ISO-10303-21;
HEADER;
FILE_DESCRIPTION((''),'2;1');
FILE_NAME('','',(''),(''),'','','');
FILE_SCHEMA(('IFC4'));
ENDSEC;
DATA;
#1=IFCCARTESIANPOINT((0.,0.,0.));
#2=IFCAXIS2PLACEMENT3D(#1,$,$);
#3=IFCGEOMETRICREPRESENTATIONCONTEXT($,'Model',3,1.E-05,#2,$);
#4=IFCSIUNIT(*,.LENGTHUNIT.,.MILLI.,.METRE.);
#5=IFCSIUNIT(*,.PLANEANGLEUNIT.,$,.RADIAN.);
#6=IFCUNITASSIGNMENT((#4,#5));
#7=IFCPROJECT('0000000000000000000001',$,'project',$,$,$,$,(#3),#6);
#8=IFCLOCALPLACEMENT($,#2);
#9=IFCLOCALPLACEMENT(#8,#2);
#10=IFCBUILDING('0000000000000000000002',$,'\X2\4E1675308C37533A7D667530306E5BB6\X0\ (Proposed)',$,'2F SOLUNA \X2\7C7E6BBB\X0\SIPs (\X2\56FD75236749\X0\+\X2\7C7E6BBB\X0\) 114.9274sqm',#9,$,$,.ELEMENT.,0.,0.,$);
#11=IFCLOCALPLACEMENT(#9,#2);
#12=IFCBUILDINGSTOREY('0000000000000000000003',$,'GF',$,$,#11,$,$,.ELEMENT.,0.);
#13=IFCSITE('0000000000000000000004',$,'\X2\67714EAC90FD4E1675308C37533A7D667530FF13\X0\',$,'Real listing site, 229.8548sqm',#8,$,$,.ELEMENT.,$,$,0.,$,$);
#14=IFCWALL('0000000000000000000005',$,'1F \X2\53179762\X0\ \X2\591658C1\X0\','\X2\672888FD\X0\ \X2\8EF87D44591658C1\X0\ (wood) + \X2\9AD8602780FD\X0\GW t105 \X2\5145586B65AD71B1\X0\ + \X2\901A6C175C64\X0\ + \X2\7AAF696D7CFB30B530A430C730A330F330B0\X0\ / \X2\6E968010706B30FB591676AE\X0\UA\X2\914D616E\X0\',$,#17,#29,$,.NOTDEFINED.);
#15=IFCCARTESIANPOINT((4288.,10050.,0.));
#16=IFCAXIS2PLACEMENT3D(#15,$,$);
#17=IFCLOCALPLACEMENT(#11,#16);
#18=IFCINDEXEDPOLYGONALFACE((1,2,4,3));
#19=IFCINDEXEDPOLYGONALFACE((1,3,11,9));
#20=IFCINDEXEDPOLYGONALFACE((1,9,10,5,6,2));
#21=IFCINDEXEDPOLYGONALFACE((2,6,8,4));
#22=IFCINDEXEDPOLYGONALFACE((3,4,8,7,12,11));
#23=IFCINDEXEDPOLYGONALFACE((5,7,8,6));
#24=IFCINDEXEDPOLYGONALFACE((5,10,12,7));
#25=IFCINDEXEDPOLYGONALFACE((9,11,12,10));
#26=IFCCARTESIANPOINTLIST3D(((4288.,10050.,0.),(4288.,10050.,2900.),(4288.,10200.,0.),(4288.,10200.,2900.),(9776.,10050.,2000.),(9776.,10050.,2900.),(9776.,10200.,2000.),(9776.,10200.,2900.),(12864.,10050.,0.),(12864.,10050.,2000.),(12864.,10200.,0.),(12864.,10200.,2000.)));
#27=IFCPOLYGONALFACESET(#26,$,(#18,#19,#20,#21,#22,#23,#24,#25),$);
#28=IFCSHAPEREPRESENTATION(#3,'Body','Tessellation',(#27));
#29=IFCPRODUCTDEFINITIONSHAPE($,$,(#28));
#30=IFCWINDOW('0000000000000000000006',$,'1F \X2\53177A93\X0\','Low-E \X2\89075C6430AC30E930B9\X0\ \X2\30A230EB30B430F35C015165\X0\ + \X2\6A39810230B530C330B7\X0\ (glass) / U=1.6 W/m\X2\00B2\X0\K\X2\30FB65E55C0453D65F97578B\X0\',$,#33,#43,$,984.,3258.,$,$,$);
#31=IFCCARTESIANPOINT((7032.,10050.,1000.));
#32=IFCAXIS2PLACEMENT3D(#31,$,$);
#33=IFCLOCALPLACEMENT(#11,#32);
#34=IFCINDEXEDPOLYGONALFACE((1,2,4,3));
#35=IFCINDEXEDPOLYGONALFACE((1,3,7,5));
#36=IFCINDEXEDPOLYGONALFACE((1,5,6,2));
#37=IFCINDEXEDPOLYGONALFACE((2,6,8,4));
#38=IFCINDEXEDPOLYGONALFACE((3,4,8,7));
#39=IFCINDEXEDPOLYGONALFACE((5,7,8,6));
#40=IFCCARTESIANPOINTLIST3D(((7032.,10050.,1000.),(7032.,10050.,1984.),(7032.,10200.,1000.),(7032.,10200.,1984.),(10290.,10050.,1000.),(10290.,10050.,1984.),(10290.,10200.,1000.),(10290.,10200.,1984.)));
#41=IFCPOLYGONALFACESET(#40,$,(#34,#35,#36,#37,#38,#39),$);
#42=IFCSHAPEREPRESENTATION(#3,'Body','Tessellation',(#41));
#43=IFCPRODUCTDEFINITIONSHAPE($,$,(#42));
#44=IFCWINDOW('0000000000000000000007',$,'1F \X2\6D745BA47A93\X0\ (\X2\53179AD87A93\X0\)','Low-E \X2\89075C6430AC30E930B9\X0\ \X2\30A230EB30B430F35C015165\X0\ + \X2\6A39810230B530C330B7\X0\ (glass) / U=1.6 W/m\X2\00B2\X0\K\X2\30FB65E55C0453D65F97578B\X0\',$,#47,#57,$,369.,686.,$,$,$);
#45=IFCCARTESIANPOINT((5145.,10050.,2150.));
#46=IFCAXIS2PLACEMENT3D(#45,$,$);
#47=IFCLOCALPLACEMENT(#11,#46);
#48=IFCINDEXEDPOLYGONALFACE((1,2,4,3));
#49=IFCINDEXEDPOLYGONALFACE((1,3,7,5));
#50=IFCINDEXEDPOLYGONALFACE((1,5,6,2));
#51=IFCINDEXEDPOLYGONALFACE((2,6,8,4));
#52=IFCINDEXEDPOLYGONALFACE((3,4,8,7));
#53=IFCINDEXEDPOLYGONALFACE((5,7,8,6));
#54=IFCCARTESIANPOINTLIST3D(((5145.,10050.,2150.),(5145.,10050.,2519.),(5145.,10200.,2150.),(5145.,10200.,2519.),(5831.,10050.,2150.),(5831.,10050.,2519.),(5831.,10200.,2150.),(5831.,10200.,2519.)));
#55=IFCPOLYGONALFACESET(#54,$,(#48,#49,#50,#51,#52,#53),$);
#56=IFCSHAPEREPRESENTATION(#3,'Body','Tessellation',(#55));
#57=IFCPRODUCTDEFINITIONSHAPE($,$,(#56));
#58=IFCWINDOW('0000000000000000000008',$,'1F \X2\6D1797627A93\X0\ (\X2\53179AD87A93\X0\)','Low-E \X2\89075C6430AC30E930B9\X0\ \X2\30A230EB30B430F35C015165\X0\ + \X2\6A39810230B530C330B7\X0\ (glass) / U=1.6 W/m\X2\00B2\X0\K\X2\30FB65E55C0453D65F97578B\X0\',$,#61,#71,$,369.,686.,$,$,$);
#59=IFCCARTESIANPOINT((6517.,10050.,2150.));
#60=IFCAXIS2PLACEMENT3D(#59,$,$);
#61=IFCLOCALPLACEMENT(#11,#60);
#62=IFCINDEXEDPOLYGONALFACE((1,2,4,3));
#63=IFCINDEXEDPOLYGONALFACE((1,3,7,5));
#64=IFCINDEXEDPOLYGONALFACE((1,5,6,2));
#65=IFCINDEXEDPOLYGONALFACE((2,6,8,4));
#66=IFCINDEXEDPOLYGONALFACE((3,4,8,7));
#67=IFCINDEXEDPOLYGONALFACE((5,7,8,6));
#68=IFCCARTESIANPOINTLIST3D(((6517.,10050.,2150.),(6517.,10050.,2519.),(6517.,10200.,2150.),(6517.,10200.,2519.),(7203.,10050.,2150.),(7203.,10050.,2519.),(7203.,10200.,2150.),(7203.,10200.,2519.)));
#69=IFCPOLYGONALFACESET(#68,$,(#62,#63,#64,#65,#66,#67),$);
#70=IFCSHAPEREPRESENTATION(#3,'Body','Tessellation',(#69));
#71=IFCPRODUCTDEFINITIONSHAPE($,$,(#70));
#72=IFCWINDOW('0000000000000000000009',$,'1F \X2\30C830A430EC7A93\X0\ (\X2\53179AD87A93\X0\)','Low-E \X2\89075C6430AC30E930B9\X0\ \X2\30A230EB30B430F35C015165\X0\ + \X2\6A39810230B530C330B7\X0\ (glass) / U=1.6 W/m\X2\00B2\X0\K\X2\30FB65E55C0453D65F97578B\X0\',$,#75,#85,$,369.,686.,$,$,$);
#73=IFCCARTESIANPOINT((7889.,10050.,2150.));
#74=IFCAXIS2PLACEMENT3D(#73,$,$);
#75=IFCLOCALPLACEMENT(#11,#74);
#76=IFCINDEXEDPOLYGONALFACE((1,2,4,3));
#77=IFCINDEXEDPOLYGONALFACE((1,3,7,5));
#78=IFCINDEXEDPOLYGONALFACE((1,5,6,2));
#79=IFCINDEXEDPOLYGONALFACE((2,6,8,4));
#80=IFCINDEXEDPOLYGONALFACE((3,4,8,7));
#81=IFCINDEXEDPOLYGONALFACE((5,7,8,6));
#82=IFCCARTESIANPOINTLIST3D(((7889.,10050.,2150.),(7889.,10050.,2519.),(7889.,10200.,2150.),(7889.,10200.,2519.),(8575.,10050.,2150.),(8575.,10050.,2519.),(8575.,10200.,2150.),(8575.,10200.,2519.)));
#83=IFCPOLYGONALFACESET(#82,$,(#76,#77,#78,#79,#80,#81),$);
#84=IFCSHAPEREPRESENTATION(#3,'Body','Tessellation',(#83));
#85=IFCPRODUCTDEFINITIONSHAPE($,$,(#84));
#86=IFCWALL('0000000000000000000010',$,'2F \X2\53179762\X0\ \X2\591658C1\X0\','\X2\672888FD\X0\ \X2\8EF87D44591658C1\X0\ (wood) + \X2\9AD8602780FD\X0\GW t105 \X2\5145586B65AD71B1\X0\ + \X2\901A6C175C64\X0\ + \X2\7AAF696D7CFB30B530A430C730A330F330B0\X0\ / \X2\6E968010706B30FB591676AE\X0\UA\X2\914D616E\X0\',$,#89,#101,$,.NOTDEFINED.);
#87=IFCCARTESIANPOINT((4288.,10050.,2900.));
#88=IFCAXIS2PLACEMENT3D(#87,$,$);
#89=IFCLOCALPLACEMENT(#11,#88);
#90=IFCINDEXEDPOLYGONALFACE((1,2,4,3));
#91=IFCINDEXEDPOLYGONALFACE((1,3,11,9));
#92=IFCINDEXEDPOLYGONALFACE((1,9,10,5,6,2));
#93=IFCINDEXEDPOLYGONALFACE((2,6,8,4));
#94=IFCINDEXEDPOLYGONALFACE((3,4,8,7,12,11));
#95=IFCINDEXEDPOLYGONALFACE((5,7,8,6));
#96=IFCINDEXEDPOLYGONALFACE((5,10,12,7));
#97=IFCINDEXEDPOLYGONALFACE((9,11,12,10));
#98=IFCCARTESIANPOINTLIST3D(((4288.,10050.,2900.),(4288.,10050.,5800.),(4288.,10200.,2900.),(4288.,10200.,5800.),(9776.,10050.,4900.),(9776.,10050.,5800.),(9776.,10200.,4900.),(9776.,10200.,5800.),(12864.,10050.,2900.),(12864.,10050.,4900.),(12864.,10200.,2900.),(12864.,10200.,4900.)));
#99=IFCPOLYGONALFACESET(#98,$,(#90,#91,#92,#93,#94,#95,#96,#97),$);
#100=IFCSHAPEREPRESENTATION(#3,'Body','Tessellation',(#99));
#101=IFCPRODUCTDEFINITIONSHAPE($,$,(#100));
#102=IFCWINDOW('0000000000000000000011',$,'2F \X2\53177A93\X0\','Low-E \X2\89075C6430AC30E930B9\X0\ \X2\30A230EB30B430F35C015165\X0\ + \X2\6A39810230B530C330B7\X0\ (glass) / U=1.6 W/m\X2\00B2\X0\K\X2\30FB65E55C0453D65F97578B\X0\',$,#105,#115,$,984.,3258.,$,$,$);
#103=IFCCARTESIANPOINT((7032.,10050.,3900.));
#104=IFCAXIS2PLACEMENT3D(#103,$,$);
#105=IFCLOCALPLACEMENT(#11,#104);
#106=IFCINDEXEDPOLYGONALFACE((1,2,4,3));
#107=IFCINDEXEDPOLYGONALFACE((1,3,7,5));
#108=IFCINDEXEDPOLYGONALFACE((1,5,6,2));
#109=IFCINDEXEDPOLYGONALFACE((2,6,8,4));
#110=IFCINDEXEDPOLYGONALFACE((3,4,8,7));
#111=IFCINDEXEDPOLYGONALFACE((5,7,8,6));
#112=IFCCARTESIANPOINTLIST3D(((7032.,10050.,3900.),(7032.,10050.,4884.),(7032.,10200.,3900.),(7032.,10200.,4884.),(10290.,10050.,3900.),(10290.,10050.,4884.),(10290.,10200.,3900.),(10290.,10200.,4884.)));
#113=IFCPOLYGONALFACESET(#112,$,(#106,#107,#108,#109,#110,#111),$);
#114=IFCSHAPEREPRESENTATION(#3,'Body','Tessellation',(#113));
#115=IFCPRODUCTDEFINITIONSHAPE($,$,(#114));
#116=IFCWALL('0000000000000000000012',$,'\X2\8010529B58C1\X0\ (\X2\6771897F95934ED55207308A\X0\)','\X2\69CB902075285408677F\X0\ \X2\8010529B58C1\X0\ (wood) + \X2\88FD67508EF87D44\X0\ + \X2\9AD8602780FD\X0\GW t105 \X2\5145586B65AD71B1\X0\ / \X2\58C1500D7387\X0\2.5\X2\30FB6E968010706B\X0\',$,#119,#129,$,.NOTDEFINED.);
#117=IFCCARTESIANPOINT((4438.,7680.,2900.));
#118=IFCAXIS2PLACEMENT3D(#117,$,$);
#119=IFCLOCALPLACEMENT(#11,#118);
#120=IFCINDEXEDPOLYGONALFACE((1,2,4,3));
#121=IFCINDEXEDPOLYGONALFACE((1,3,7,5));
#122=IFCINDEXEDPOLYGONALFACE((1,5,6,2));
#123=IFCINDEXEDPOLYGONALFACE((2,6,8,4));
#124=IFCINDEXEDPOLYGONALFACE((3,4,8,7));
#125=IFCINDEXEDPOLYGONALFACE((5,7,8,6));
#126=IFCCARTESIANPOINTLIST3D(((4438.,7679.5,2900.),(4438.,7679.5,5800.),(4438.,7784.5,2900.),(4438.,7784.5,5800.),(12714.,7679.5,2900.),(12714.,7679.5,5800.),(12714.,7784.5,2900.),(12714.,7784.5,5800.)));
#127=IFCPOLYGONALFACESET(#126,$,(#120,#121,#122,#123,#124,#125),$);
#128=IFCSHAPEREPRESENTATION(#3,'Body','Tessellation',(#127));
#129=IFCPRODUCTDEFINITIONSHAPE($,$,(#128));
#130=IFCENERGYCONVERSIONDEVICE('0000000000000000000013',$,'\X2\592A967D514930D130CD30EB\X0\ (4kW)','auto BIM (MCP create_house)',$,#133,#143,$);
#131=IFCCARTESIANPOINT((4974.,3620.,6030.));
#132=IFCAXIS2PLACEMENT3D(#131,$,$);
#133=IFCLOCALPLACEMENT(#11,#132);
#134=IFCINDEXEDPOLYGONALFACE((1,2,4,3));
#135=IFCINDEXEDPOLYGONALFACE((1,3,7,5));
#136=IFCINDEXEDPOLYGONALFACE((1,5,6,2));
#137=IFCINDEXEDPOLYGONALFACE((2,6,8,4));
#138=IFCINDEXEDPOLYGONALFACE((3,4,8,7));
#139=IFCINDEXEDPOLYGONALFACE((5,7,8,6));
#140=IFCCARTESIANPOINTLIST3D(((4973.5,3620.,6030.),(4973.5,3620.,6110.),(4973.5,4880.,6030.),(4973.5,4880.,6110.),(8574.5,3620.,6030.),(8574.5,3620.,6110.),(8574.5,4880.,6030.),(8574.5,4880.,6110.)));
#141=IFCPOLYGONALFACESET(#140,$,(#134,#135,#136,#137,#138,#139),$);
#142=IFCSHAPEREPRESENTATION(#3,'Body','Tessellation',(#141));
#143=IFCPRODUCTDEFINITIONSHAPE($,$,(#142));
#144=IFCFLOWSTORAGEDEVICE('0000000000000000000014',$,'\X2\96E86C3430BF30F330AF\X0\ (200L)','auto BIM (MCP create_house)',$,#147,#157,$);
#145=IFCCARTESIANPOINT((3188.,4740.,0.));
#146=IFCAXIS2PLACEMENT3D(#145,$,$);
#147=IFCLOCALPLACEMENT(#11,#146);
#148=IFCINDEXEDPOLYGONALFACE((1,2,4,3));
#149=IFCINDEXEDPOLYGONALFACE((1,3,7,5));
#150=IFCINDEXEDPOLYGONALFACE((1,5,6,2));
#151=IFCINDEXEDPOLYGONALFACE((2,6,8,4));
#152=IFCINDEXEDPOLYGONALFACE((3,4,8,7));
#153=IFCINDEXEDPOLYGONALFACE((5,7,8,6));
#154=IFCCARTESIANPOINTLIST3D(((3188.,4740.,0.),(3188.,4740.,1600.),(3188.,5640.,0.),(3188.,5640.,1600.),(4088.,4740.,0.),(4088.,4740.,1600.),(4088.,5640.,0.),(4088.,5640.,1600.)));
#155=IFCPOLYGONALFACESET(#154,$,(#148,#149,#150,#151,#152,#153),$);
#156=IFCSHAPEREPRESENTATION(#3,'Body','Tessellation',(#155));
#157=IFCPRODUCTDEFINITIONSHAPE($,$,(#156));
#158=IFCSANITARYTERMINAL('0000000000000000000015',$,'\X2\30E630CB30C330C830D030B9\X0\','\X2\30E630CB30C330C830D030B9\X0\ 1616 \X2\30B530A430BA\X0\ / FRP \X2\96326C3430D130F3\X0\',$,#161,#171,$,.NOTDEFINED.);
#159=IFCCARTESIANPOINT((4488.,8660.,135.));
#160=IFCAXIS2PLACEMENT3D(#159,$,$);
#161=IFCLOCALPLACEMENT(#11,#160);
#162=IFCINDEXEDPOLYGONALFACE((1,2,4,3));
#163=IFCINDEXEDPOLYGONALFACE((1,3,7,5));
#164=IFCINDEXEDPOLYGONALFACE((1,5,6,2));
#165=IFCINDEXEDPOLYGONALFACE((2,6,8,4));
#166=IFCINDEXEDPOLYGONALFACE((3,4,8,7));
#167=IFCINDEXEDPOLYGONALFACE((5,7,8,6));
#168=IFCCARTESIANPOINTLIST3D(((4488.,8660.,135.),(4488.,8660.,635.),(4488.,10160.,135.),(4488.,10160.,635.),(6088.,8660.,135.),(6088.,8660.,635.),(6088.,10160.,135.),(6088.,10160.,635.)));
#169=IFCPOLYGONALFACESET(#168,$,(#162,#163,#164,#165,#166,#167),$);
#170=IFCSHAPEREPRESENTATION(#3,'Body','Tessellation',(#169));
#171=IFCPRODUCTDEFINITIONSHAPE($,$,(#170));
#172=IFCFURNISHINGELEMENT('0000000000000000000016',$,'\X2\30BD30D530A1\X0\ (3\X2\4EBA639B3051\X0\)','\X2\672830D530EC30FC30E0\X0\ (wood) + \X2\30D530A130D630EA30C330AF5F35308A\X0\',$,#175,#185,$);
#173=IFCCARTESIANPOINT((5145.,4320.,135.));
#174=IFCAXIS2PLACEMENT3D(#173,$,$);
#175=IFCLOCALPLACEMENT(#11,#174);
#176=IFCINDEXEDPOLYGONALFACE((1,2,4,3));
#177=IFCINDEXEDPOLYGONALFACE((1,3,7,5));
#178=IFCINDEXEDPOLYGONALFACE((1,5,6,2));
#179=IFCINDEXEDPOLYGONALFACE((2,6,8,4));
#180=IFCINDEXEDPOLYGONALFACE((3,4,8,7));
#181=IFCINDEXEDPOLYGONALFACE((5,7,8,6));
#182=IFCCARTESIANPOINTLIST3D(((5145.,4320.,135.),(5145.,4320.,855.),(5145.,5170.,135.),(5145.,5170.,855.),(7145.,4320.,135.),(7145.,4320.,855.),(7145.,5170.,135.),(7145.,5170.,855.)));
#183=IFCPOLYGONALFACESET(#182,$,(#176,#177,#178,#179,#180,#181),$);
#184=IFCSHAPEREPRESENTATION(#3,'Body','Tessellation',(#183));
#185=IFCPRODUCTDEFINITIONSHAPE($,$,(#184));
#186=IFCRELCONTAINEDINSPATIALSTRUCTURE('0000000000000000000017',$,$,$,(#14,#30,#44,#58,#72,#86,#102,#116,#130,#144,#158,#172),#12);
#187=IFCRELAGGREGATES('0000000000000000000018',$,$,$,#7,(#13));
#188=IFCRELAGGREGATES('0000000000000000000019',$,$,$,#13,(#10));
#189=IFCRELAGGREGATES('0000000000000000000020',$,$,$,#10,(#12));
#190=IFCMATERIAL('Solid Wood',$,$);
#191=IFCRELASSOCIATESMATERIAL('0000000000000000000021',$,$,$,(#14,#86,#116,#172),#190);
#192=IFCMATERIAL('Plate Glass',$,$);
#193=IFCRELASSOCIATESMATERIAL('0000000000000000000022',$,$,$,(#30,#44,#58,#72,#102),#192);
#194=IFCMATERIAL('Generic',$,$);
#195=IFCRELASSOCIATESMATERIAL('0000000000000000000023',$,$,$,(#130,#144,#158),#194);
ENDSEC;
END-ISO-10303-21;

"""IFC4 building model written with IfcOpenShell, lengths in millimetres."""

from ifc_helpers import new_model, si_unit, frame, frame_2d, origin, place, context, project, spatial, rectangle, extrude, material, element, fill, save


model = new_model("IFC4")

# Units and contexts
model_context = context("Model", 3, precision=1e-05, world=origin())
ifc_project = project(units=[si_unit("LENGTHUNIT", "METRE", prefix="MILLI"), si_unit("PLANEANGLEUNIT", "RADIAN")], contexts=[model_context])

# Site, building, storey
site_placement = place(None, origin())
site = spatial("IfcSite", under=ifc_project, at=site_placement, Name="東京都世田谷区給田３", ObjectType="Real listing site, 229.8548sqm", CompositionType="ELEMENT", RefElevation=0.0)
building_placement = place(site_placement, origin())
building = spatial("IfcBuilding", under=site, at=building_placement, Name="世田谷区給田の家 (Proposed)", ObjectType="2F SOLUNA 籾殻SIPs (国産杉+籾殻) 114.9274sqm", CompositionType="ELEMENT", ElevationOfRefHeight=0.0, ElevationOfTerrain=0.0)
storey_placement = place(building_placement, origin())
storey = spatial("IfcBuildingStorey", under=building, at=storey_placement, Name="GF", CompositionType="ELEMENT", Elevation=0.0)

# Wall, openings, windows
ifc_material_1 = material(Name="Solid Wood")
wall_1_placement = place(storey_placement, frame((4288.0, 10050.0, 0.0)))
wall_1 = element("IfcWall", 1, at=wall_1_placement, inside=storey, material=ifc_material_1, Name="1F 北面 外壁", Description="木製 軸組外壁 (wood) + 高性能GW t105 充填断熱 + 通気層 + 窯業系サイディング / 準耐火・外皮UA配慮", PredefinedType="NOTDEFINED", context=model_context, shape_type="SweptSolid", body=[
    extrude(rectangle(XDim=8576.0, YDim=150.0, at=frame_2d((4288.0, 75.0))), frame((4288.0, 10050.0, 0.0)), (0.0, 0.0, 1.0), 2900.0),
])
opening_1_placement = place(storey_placement, frame((7032.0, 10050.0, 1000.0)))
opening_1 = element("IfcOpeningElement", 2, at=opening_1_placement, cuts=wall_1, PredefinedType="NOTDEFINED", context=model_context, shape_type="SweptSolid", body=[
    extrude(rectangle(XDim=3258.0, YDim=150.0, at=frame_2d((1629.0, 75.0))), frame((7032.0, 10050.0, 1000.0)), (0.0, 0.0, 1.0), 984.0),
])
opening_2_placement = place(storey_placement, frame((5145.0, 10050.0, 2150.0)))
opening_2 = element("IfcOpeningElement", 3, at=opening_2_placement, cuts=wall_1, PredefinedType="NOTDEFINED", context=model_context, shape_type="SweptSolid", body=[
    extrude(rectangle(XDim=686.0, YDim=150.0, at=frame_2d((343.0, 75.0))), frame((5145.0, 10050.0, 2150.0)), (0.0, 0.0, 1.0), 369.0),
])
opening_3_placement = place(storey_placement, frame((6517.0, 10050.0, 2150.0)))
opening_3 = element("IfcOpeningElement", 4, at=opening_3_placement, cuts=wall_1, PredefinedType="NOTDEFINED", context=model_context, shape_type="SweptSolid", body=[
    extrude(rectangle(XDim=686.0, YDim=150.0, at=frame_2d((343.0, 75.0))), frame((6517.0, 10050.0, 2150.0)), (0.0, 0.0, 1.0), 369.0),
])
opening_4_placement = place(storey_placement, frame((7889.0, 10050.0, 2150.0)))
opening_4 = element("IfcOpeningElement", 5, at=opening_4_placement, cuts=wall_1, PredefinedType="NOTDEFINED", context=model_context, shape_type="SweptSolid", body=[
    extrude(rectangle(XDim=686.0, YDim=150.0, at=frame_2d((343.0, 75.0))), frame((7889.0, 10050.0, 2150.0)), (0.0, 0.0, 1.0), 369.0),
])
ifc_material_2 = material(Name="Plate Glass")
window_1_placement = place(storey_placement, frame((7032.0, 10050.0, 1000.0)))
window_1 = element("IfcWindow", 6, at=window_1_placement, inside=storey, material=ifc_material_2, Name="1F 北窓", Description="Low-E 複層ガラス アルゴン封入 + 樹脂サッシ (glass) / U=1.6 W/m²K・日射取得型", OverallHeight=984.0, OverallWidth=3258.0, context=model_context, shape_type="SweptSolid", body=[
    extrude(rectangle(XDim=3258.0, YDim=150.0, at=frame_2d((1629.0, 75.0))), frame((7032.0, 10050.0, 1000.0)), (0.0, 0.0, 1.0), 984.0),
])
fill(opening_1, window_1)
window_2_placement = place(storey_placement, frame((5145.0, 10050.0, 2150.0)))
window_2 = element("IfcWindow", 7, at=window_2_placement, inside=storey, material=ifc_material_2, Name="1F 浴室窓 (北高窓)", Description="Low-E 複層ガラス アルゴン封入 + 樹脂サッシ (glass) / U=1.6 W/m²K・日射取得型", OverallHeight=369.0, OverallWidth=686.0, context=model_context, shape_type="SweptSolid", body=[
    extrude(rectangle(XDim=686.0, YDim=150.0, at=frame_2d((343.0, 75.0))), frame((5145.0, 10050.0, 2150.0)), (0.0, 0.0, 1.0), 369.0),
])
fill(opening_2, window_2)
window_3_placement = place(storey_placement, frame((6517.0, 10050.0, 2150.0)))
window_3 = element("IfcWindow", 8, at=window_3_placement, inside=storey, material=ifc_material_2, Name="1F 洗面窓 (北高窓)", Description="Low-E 複層ガラス アルゴン封入 + 樹脂サッシ (glass) / U=1.6 W/m²K・日射取得型", OverallHeight=369.0, OverallWidth=686.0, context=model_context, shape_type="SweptSolid", body=[
    extrude(rectangle(XDim=686.0, YDim=150.0, at=frame_2d((343.0, 75.0))), frame((6517.0, 10050.0, 2150.0)), (0.0, 0.0, 1.0), 369.0),
])
fill(opening_3, window_3)
window_4_placement = place(storey_placement, frame((7889.0, 10050.0, 2150.0)))
window_4 = element("IfcWindow", 9, at=window_4_placement, inside=storey, material=ifc_material_2, Name="1F トイレ窓 (北高窓)", Description="Low-E 複層ガラス アルゴン封入 + 樹脂サッシ (glass) / U=1.6 W/m²K・日射取得型", OverallHeight=369.0, OverallWidth=686.0, context=model_context, shape_type="SweptSolid", body=[
    extrude(rectangle(XDim=686.0, YDim=150.0, at=frame_2d((343.0, 75.0))), frame((7889.0, 10050.0, 2150.0)), (0.0, 0.0, 1.0), 369.0),
])
fill(opening_4, window_4)

# Wall, opening, window
wall_2_placement = place(storey_placement, frame((4288.0, 10050.0, 2900.0)))
wall_2 = element("IfcWall", 10, at=wall_2_placement, inside=storey, material=ifc_material_1, Name="2F 北面 外壁", Description="木製 軸組外壁 (wood) + 高性能GW t105 充填断熱 + 通気層 + 窯業系サイディング / 準耐火・外皮UA配慮", PredefinedType="NOTDEFINED", context=model_context, shape_type="SweptSolid", body=[
    extrude(rectangle(XDim=8576.0, YDim=150.0, at=frame_2d((4288.0, 75.0))), frame((4288.0, 10050.0, 2900.0)), (0.0, 0.0, 1.0), 2900.0),
])
opening_5_placement = place(storey_placement, frame((7032.0, 10050.0, 3900.0)))
opening_5 = element("IfcOpeningElement", 11, at=opening_5_placement, cuts=wall_2, PredefinedType="NOTDEFINED", context=model_context, shape_type="SweptSolid", body=[
    extrude(rectangle(XDim=3258.0, YDim=150.0, at=frame_2d((1629.0, 75.0))), frame((7032.0, 10050.0, 3900.0)), (0.0, 0.0, 1.0), 984.0),
])
window_5_placement = place(storey_placement, frame((7032.0, 10050.0, 3900.0)))
window_5 = element("IfcWindow", 12, at=window_5_placement, inside=storey, material=ifc_material_2, Name="2F 北窓", Description="Low-E 複層ガラス アルゴン封入 + 樹脂サッシ (glass) / U=1.6 W/m²K・日射取得型", OverallHeight=984.0, OverallWidth=3258.0, context=model_context, shape_type="SweptSolid", body=[
    extrude(rectangle(XDim=3258.0, YDim=150.0, at=frame_2d((1629.0, 75.0))), frame((7032.0, 10050.0, 3900.0)), (0.0, 0.0, 1.0), 984.0),
])
fill(opening_5, window_5)

# Wall
wall_3_placement = place(storey_placement, frame((4438.0, 7680.0, 2900.0)))
element("IfcWall", 13, at=wall_3_placement, inside=storey, material=ifc_material_1, Name="耐力壁 (東西間仕切り)", Description="構造用合板 耐力壁 (wood) + 製材軸組 + 高性能GW t105 充填断熱 / 壁倍率2.5・準耐火", PredefinedType="NOTDEFINED", context=model_context, shape_type="SweptSolid", body=[
    extrude(rectangle(XDim=8276.0, YDim=105.0, at=frame_2d((4138.0, 52.0))), frame((4438.0, 7680.0, 2900.0)), (0.0, 0.0, 1.0), 2900.0),
])

# Energy conversion device
ifc_material_3 = material(Name="Generic")
energy_conversion_device_placement = place(storey_placement, frame((4974.0, 3620.0, 6030.0)))
element("IfcEnergyConversionDevice", 14, at=energy_conversion_device_placement, inside=storey, material=ifc_material_3, Name="太陽光パネル (4kW)", Description="auto BIM (MCP create_house)", context=model_context, shape_type="SweptSolid", body=[
    extrude(rectangle(XDim=3601.0, YDim=1260.0, at=frame_2d((1800.0, 630.0))), frame((4974.0, 3620.0, 6030.0)), (0.0, 0.0, 1.0), 80.0),
])

# Flow storage device
flow_storage_device_placement = place(storey_placement, frame((3188.0, 4740.0, 0.0)))
element("IfcFlowStorageDevice", 15, at=flow_storage_device_placement, inside=storey, material=ifc_material_3, Name="雨水タンク (200L)", Description="auto BIM (MCP create_house)", context=model_context, shape_type="SweptSolid", body=[
    extrude(rectangle(XDim=900.0, YDim=900.0, at=frame_2d((450.0, 450.0))), frame((3188.0, 4740.0, 0.0)), (0.0, 0.0, 1.0), 1600.0),
])

# Sanitary terminal
sanitary_terminal_placement = place(storey_placement, frame((4488.0, 8660.0, 135.0)))
element("IfcSanitaryTerminal", 16, at=sanitary_terminal_placement, inside=storey, material=ifc_material_3, Name="ユニットバス", Description="ユニットバス 1616 サイズ / FRP 防水パン", PredefinedType="NOTDEFINED", context=model_context, shape_type="SweptSolid", body=[
    extrude(rectangle(XDim=1600.0, YDim=1500.0, at=frame_2d((800.0, 750.0))), frame((4488.0, 8660.0, 135.0)), (0.0, 0.0, 1.0), 500.0),
])

# Furnishing element
furnishing_1_placement = place(storey_placement, frame((5145.0, 4320.0, 135.0)))
element("IfcFurnishingElement", 17, at=furnishing_1_placement, inside=storey, material=ifc_material_1, Name="ソファ (3人掛け)", Description="木フレーム (wood) + ファブリック張り", context=model_context, shape_type="SweptSolid", body=[
    extrude(rectangle(XDim=2000.0, YDim=850.0, at=frame_2d((1000.0, 425.0))), frame((5145.0, 4320.0, 135.0)), (0.0, 0.0, 1.0), 720.0),
])

save(model, "model.ifc")
